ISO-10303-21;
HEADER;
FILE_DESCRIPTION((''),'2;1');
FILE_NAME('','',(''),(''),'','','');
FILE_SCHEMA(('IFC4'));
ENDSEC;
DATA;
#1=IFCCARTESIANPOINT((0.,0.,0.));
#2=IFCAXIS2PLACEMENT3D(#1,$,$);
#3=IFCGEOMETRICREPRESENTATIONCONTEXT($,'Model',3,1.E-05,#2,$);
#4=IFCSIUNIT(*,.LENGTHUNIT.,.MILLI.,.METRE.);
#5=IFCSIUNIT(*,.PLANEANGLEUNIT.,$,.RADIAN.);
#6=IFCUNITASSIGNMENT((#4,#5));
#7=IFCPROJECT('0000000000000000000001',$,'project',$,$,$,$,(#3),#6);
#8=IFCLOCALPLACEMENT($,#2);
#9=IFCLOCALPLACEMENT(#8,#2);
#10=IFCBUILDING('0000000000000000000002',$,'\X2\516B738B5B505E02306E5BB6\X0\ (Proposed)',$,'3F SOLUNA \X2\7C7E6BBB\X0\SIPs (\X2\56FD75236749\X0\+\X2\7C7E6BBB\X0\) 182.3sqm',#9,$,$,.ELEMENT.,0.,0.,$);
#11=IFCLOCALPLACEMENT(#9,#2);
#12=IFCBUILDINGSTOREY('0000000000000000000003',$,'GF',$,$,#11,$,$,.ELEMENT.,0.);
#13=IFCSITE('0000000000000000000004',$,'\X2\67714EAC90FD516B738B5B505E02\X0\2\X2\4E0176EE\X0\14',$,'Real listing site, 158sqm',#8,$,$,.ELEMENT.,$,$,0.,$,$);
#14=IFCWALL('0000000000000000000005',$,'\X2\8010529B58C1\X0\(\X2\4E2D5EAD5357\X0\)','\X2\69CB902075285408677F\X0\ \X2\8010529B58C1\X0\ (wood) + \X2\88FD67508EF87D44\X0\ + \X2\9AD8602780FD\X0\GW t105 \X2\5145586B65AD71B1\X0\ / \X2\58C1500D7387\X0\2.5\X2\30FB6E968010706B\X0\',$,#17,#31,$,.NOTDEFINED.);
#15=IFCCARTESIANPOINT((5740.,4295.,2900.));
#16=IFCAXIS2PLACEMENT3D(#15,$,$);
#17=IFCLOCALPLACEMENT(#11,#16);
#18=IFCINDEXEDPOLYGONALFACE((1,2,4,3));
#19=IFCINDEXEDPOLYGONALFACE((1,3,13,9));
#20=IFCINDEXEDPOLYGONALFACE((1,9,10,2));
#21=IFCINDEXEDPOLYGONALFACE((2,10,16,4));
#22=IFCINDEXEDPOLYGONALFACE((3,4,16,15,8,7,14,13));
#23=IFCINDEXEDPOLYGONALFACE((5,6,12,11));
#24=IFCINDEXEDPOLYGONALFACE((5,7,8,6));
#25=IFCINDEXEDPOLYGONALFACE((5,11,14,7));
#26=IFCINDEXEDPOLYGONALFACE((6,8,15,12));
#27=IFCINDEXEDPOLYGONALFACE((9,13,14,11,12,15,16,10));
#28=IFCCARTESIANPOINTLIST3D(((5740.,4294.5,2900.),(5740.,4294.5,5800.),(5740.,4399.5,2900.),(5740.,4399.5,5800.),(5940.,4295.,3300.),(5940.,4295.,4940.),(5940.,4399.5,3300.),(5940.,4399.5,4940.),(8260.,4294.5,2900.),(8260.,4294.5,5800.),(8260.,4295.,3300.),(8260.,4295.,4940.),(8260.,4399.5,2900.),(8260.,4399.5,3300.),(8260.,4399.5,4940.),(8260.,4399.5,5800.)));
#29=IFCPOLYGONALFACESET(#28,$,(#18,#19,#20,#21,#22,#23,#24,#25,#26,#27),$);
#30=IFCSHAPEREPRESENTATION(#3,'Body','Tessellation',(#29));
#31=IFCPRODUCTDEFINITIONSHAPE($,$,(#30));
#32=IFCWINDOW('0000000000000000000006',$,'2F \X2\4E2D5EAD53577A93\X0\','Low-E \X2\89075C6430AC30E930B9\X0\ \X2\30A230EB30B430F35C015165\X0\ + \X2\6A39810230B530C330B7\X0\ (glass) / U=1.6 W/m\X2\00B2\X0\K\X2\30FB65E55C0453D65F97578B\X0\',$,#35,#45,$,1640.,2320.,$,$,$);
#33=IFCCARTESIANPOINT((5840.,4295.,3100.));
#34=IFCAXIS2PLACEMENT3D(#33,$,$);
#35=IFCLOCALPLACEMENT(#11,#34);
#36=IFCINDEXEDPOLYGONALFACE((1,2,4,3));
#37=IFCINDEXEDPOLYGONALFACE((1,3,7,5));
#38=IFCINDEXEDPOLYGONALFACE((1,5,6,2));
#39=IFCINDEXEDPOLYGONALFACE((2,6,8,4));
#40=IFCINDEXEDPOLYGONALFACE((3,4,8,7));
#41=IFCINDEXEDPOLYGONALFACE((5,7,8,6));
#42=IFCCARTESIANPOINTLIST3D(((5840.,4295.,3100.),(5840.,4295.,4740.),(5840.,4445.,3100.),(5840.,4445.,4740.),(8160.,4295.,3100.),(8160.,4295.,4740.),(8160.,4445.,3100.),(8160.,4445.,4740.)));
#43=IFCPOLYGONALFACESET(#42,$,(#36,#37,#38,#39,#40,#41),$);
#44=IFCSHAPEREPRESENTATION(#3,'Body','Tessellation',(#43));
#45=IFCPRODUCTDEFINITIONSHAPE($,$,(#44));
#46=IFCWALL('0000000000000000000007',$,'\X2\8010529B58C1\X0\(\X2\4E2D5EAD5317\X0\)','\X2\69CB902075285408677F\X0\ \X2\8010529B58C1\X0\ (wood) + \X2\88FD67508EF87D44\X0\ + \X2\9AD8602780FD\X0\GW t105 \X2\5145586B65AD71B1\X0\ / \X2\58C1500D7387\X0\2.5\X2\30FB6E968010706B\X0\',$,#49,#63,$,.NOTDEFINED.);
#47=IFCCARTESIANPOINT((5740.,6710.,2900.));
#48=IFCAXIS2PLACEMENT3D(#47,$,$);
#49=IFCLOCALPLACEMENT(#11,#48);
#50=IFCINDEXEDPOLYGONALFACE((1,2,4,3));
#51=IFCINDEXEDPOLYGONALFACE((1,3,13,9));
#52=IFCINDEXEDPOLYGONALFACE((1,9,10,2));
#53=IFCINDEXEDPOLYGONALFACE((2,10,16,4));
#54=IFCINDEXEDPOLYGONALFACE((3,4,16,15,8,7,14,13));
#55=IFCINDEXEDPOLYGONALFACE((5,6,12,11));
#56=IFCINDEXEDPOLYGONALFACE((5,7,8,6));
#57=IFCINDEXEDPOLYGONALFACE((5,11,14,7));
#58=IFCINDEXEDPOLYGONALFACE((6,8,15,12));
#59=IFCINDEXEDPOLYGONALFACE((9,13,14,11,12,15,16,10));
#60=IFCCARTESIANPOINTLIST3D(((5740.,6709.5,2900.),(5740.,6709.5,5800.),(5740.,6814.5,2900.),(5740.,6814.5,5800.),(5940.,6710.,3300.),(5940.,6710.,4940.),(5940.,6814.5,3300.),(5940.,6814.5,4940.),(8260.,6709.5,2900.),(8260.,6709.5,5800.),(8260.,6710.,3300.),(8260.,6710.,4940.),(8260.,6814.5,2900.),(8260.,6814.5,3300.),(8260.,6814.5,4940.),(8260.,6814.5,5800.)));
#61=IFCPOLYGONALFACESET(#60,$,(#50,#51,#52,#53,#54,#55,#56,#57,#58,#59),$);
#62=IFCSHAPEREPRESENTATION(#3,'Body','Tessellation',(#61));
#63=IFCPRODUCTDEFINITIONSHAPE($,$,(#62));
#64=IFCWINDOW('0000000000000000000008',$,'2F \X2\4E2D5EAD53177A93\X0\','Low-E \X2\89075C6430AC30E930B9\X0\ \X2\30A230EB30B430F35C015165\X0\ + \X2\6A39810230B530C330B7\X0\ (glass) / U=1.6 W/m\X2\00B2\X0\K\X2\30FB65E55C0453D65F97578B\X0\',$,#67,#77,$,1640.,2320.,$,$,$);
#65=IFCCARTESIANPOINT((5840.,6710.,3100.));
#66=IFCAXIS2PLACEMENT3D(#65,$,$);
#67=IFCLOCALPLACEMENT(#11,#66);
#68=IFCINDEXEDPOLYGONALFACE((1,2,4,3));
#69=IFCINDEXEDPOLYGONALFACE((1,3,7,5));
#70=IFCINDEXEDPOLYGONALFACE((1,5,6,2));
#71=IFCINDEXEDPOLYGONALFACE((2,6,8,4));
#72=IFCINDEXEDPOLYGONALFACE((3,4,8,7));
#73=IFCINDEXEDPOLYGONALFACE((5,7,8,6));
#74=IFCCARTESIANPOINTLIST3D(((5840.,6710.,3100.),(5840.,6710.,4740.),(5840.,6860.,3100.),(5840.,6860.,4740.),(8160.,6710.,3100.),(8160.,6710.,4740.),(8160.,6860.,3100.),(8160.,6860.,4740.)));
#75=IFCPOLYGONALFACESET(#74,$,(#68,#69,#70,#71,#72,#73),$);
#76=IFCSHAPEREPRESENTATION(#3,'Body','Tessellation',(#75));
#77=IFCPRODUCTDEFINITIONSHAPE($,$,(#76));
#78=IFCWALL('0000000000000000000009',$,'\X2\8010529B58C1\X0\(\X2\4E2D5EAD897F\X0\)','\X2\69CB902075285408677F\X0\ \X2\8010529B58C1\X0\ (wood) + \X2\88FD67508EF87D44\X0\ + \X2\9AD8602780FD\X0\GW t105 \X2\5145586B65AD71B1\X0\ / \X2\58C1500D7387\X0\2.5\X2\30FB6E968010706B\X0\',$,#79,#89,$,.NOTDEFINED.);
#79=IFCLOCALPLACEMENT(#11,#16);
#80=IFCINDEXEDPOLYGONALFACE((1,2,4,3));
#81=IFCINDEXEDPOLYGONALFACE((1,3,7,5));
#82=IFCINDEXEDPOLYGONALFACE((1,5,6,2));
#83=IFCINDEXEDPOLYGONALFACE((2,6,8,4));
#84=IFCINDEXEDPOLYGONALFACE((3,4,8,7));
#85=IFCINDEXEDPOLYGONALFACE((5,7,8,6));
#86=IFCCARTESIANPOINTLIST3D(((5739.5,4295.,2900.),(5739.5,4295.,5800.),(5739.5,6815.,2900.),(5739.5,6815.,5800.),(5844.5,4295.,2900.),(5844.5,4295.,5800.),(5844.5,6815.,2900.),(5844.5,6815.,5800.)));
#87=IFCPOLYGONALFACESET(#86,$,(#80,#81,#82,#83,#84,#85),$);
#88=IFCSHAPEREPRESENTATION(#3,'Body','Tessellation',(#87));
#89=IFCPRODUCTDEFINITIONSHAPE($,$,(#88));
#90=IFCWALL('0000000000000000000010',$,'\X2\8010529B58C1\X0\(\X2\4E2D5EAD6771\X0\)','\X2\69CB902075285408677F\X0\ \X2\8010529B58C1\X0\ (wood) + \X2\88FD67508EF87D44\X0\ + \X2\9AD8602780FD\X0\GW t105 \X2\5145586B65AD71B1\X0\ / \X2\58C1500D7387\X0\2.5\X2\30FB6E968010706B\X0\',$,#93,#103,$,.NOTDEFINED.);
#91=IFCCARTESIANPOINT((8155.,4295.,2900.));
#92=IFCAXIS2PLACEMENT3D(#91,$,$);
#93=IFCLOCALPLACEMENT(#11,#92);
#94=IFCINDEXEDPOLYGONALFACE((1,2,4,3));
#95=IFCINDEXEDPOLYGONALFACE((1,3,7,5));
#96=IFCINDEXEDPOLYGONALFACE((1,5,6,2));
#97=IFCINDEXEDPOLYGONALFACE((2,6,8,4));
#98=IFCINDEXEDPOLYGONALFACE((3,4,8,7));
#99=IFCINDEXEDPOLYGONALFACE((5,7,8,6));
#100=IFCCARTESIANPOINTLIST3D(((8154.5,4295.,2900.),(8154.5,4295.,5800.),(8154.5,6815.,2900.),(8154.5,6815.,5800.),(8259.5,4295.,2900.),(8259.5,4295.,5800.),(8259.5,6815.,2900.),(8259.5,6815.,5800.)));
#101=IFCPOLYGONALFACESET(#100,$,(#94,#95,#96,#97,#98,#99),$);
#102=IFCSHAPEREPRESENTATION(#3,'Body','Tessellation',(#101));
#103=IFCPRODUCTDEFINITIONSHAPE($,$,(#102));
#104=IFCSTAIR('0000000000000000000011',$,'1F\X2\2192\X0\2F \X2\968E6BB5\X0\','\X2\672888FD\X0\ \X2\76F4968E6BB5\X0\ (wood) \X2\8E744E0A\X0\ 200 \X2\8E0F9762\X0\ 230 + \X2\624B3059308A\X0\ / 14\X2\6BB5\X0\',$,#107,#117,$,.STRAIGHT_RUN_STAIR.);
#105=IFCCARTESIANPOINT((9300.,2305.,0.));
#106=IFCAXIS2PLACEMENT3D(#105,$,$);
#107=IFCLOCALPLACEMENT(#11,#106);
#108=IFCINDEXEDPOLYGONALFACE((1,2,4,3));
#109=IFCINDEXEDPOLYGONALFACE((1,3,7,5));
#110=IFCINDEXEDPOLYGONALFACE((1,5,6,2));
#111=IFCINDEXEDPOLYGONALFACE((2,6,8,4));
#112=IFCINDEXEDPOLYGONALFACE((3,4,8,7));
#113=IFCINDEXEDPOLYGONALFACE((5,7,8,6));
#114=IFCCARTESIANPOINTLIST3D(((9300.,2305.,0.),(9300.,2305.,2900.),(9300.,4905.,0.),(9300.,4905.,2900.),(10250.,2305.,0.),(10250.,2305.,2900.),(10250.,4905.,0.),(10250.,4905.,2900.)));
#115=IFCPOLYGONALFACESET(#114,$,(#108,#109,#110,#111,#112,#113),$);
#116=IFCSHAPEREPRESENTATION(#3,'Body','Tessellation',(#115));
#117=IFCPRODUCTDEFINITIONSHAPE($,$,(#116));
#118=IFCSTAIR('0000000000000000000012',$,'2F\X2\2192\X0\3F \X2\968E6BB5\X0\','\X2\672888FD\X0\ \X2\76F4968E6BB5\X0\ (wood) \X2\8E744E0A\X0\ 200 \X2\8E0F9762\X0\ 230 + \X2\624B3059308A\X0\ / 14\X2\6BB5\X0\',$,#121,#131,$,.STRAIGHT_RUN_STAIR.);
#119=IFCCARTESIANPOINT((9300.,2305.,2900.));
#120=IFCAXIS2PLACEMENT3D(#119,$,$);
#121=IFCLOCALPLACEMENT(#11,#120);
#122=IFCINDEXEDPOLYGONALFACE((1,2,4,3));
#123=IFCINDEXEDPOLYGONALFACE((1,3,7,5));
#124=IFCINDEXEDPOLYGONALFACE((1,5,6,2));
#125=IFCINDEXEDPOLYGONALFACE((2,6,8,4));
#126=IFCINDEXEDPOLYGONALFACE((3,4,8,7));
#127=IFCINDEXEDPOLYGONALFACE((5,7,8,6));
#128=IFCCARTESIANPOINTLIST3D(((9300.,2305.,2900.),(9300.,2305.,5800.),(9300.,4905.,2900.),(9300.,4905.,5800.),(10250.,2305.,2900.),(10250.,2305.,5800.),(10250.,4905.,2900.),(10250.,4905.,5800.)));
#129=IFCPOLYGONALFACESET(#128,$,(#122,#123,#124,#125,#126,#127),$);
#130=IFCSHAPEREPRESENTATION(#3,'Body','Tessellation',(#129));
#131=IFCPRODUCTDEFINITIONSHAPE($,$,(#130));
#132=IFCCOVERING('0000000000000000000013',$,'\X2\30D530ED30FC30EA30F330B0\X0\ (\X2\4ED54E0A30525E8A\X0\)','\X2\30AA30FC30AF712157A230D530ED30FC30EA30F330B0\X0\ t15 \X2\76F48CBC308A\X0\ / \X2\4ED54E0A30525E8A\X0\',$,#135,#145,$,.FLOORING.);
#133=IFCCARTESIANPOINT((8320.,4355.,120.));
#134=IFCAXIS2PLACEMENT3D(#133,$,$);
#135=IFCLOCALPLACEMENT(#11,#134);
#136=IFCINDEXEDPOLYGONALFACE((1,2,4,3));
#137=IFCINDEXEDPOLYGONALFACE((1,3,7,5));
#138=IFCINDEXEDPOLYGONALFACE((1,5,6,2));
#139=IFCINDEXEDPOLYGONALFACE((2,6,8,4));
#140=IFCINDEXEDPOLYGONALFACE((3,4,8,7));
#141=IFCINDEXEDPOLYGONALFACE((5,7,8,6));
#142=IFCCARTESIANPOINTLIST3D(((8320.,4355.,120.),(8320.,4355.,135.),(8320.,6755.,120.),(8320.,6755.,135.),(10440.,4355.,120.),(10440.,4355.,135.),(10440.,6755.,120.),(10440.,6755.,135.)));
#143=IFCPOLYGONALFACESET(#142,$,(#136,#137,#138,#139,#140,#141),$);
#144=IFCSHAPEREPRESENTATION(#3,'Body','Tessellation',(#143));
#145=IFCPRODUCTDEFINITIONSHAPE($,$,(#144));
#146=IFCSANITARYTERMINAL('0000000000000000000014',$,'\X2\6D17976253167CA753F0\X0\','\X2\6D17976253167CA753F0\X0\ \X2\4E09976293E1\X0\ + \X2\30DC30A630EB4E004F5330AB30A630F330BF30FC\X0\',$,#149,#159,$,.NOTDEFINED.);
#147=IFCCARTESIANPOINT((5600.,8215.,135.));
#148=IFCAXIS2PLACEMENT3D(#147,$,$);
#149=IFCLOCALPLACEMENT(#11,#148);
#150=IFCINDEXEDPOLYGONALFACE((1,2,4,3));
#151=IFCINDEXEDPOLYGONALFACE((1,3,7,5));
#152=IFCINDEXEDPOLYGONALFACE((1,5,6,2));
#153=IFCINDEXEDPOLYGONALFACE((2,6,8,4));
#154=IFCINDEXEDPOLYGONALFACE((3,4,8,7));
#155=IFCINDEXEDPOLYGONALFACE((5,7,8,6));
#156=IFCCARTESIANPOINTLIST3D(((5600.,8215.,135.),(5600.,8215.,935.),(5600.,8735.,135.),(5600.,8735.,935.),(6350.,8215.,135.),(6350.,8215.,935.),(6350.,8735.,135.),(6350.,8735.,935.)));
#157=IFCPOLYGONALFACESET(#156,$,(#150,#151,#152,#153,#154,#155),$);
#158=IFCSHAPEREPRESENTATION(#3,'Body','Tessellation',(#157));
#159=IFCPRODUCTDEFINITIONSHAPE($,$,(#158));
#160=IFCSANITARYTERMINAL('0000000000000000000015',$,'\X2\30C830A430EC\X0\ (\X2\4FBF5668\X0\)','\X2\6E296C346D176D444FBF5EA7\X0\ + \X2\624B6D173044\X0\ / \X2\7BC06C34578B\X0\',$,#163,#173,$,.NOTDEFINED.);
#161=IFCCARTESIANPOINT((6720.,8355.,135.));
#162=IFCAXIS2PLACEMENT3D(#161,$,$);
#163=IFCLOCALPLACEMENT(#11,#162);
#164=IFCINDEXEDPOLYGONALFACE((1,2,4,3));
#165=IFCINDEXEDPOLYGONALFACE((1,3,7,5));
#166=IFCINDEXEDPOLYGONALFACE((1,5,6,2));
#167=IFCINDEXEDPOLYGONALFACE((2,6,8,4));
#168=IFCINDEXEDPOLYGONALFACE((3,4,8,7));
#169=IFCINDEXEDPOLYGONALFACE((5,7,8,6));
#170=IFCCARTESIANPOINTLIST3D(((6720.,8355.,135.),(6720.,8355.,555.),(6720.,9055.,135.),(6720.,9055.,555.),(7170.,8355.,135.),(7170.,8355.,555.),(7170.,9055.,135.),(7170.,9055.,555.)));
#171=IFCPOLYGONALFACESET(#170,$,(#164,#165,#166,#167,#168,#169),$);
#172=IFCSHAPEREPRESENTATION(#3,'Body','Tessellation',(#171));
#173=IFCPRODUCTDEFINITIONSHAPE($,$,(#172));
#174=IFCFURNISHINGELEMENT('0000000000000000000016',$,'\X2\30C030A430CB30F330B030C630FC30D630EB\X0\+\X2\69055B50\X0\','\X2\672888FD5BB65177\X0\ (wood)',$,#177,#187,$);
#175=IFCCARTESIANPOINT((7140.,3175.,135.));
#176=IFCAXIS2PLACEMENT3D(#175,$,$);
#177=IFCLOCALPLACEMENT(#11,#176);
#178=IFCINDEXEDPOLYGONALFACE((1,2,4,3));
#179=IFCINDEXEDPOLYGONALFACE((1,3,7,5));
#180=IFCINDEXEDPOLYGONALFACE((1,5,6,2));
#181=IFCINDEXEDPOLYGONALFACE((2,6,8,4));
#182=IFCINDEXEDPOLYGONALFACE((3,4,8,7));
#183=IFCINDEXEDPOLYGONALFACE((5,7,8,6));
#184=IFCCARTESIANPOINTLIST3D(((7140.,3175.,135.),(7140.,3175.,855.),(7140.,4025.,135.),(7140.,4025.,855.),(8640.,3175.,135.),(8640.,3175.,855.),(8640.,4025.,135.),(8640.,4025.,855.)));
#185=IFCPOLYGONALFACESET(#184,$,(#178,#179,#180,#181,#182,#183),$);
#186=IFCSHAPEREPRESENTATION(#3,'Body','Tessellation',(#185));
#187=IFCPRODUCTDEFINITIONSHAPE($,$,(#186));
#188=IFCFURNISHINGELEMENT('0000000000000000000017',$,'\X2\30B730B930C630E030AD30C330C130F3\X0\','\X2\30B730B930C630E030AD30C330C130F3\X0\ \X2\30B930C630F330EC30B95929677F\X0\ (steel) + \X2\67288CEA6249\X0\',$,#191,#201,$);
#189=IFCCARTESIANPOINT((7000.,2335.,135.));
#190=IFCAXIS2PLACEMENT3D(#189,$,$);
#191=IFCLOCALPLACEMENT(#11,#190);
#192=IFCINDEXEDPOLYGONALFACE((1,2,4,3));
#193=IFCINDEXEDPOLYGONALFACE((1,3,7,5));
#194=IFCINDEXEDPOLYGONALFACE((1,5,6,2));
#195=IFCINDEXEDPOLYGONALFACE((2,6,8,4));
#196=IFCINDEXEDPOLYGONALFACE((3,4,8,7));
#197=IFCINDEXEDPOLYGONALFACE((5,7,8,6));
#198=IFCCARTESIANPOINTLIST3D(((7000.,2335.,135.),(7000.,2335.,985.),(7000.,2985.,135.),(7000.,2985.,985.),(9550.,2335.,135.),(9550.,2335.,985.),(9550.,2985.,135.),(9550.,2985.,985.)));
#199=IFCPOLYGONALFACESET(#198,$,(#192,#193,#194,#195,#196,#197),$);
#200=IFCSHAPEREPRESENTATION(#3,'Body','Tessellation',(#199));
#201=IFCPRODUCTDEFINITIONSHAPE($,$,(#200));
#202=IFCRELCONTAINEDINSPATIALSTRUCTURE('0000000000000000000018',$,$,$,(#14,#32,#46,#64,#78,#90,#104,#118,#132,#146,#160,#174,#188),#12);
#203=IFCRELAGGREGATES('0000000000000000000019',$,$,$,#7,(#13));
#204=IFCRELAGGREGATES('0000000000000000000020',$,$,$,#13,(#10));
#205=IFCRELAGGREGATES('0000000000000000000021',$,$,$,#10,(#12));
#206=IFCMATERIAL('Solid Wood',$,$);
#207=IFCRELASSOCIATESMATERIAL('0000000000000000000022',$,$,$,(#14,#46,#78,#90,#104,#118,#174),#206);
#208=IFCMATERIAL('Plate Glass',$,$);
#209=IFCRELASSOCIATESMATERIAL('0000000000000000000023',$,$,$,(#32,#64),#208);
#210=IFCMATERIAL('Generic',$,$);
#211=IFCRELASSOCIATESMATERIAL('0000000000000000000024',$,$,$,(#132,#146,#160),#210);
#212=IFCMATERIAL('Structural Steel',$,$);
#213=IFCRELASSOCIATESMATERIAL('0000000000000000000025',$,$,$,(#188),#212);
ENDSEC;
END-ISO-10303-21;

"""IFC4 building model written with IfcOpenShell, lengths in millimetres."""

from ifc_helpers import new_model, si_unit, frame, frame_2d, origin, place, context, project, spatial, rectangle, extrude, material, element, fill, save


model = new_model("IFC4")

# Units and contexts
model_context = context("Model", 3, precision=1e-05, world=origin())
ifc_project = project(units=[si_unit("LENGTHUNIT", "METRE", prefix="MILLI"), si_unit("PLANEANGLEUNIT", "RADIAN")], contexts=[model_context])

# Site, building, storey
site_placement = place(None, origin())
site = spatial("IfcSite", under=ifc_project, at=site_placement, Name="東京都八王子市2丁目14", ObjectType="Real listing site, 158sqm", CompositionType="ELEMENT", RefElevation=0.0)
building_placement = place(site_placement, origin())
building = spatial("IfcBuilding", under=site, at=building_placement, Name="八王子市の家 (Proposed)", ObjectType="3F SOLUNA 籾殻SIPs (国産杉+籾殻) 182.3sqm", CompositionType="ELEMENT", ElevationOfRefHeight=0.0, ElevationOfTerrain=0.0)
storey_placement = place(building_placement, origin())
storey = spatial("IfcBuildingStorey", under=building, at=storey_placement, Name="GF", CompositionType="ELEMENT", Elevation=0.0)

# Shared definitions
ifc_material_1 = material(Name="Solid Wood")

# Shared definitions
ifc_material_2 = material(Name="Plate Glass")

# Walls, openings, windows
wall_1_placement = place(storey_placement, frame((5740.0, 4295.0, 2900.0)))
wall_1 = element("IfcWall", 1, at=wall_1_placement, inside=storey, material=ifc_material_1, Name="耐力壁(中庭南)", Description="構造用合板 耐力壁 (wood) + 製材軸組 + 高性能GW t105 充填断熱 / 壁倍率2.5・準耐火", PredefinedType="NOTDEFINED", context=model_context, shape_type="SweptSolid", body=[
    extrude(rectangle(XDim=2520.0, YDim=105.0, at=frame_2d((1260.0, 52.0))), frame((5740.0, 4295.0, 2900.0)), (0.0, 0.0, 1.0), 2900.0),
])
opening_1_placement = place(storey_placement, frame((5840.0, 4295.0, 3100.0)))
opening_1 = element("IfcOpeningElement", 2, at=opening_1_placement, cuts=wall_1, PredefinedType="NOTDEFINED", context=model_context, shape_type="SweptSolid", body=[
    extrude(rectangle(XDim=2320.0, YDim=150.0, at=frame_2d((1160.0, 75.0))), frame((5840.0, 4295.0, 3100.0)), (0.0, 0.0, 1.0), 1640.0),
])
window_1_placement = place(storey_placement, frame((5840.0, 4295.0, 3100.0)))
window_1 = element("IfcWindow", 3, at=window_1_placement, inside=storey, material=ifc_material_2, Name="2F 中庭南窓", Description="Low-E 複層ガラス アルゴン封入 + 樹脂サッシ (glass) / U=1.6 W/m²K・日射取得型", OverallHeight=1640.0, OverallWidth=2320.0, context=model_context, shape_type="SweptSolid", body=[
    extrude(rectangle(XDim=2320.0, YDim=150.0, at=frame_2d((1160.0, 75.0))), frame((5840.0, 4295.0, 3100.0)), (0.0, 0.0, 1.0), 1640.0),
])
fill(opening_1, window_1)
wall_2_placement = place(storey_placement, frame((5740.0, 6710.0, 2900.0)))
wall_2 = element("IfcWall", 4, at=wall_2_placement, inside=storey, material=ifc_material_1, Name="耐力壁(中庭北)", Description="構造用合板 耐力壁 (wood) + 製材軸組 + 高性能GW t105 充填断熱 / 壁倍率2.5・準耐火", PredefinedType="NOTDEFINED", context=model_context, shape_type="SweptSolid", body=[
    extrude(rectangle(XDim=2520.0, YDim=105.0, at=frame_2d((1260.0, 52.0))), frame((5740.0, 6710.0, 2900.0)), (0.0, 0.0, 1.0), 2900.0),
])
opening_2_placement = place(storey_placement, frame((5840.0, 6710.0, 3100.0)))
opening_2 = element("IfcOpeningElement", 5, at=opening_2_placement, cuts=wall_2, PredefinedType="NOTDEFINED", context=model_context, shape_type="SweptSolid", body=[
    extrude(rectangle(XDim=2320.0, YDim=150.0, at=frame_2d((1160.0, 75.0))), frame((5840.0, 6710.0, 3100.0)), (0.0, 0.0, 1.0), 1640.0),
])
window_2_placement = place(storey_placement, frame((5840.0, 6710.0, 3100.0)))
window_2 = element("IfcWindow", 6, at=window_2_placement, inside=storey, material=ifc_material_2, Name="2F 中庭北窓", Description="Low-E 複層ガラス アルゴン封入 + 樹脂サッシ (glass) / U=1.6 W/m²K・日射取得型", OverallHeight=1640.0, OverallWidth=2320.0, context=model_context, shape_type="SweptSolid", body=[
    extrude(rectangle(XDim=2320.0, YDim=150.0, at=frame_2d((1160.0, 75.0))), frame((5840.0, 6710.0, 3100.0)), (0.0, 0.0, 1.0), 1640.0),
])
fill(opening_2, window_2)

# Walls
wall_3_placement = place(storey_placement, frame((5740.0, 4295.0, 2900.0)))
element("IfcWall", 7, at=wall_3_placement, inside=storey, material=ifc_material_1, Name="耐力壁(中庭西)", Description="構造用合板 耐力壁 (wood) + 製材軸組 + 高性能GW t105 充填断熱 / 壁倍率2.5・準耐火", PredefinedType="NOTDEFINED", context=model_context, shape_type="SweptSolid", body=[
    extrude(rectangle(XDim=105.0, YDim=2520.0, at=frame_2d((52.0, 1260.0))), frame((5740.0, 4295.0, 2900.0)), (0.0, 0.0, 1.0), 2900.0),
])
wall_4_placement = place(storey_placement, frame((8155.0, 4295.0, 2900.0)))
element("IfcWall", 8, at=wall_4_placement, inside=storey, material=ifc_material_1, Name="耐力壁(中庭東)", Description="構造用合板 耐力壁 (wood) + 製材軸組 + 高性能GW t105 充填断熱 / 壁倍率2.5・準耐火", PredefinedType="NOTDEFINED", context=model_context, shape_type="SweptSolid", body=[
    extrude(rectangle(XDim=105.0, YDim=2520.0, at=frame_2d((52.0, 1260.0))), frame((8155.0, 4295.0, 2900.0)), (0.0, 0.0, 1.0), 2900.0),
])

# Stairs
stair_1_placement = place(storey_placement, frame((9300.0, 2305.0, 0.0)))
element("IfcStair", 9, at=stair_1_placement, inside=storey, material=ifc_material_1, Name="1F→2F 階段", Description="木製 直階段 (wood) 蹴上 200 踏面 230 + 手すり / 14段", PredefinedType="STRAIGHT_RUN_STAIR", context=model_context, shape_type="SweptSolid", body=[
    extrude(rectangle(XDim=950.0, YDim=2600.0, at=frame_2d((475.0, 1300.0))), frame((9300.0, 2305.0, 0.0)), (0.0, 0.0, 1.0), 2900.0),
])
stair_2_placement = place(storey_placement, frame((9300.0, 2305.0, 2900.0)))
element("IfcStair", 10, at=stair_2_placement, inside=storey, material=ifc_material_1, Name="2F→3F 階段", Description="木製 直階段 (wood) 蹴上 200 踏面 230 + 手すり / 14段", PredefinedType="STRAIGHT_RUN_STAIR", context=model_context, shape_type="SweptSolid", body=[
    extrude(rectangle(XDim=950.0, YDim=2600.0, at=frame_2d((475.0, 1300.0))), frame((9300.0, 2305.0, 2900.0)), (0.0, 0.0, 1.0), 2900.0),
])

# Covering
ifc_material_3 = material(Name="Generic")
covering_placement = place(storey_placement, frame((8320.0, 4355.0, 120.0)))
element("IfcCovering", 11, at=covering_placement, inside=storey, material=ifc_material_3, Name="フローリング (仕上げ床)", Description="オーク無垢フローリング t15 直貼り / 仕上げ床", PredefinedType="FLOORING", context=model_context, shape_type="SweptSolid", body=[
    extrude(rectangle(XDim=2120.0, YDim=2400.0, at=frame_2d((1060.0, 1200.0))), frame((8320.0, 4355.0, 120.0)), (0.0, 0.0, 1.0), 15.0),
])

# Sanitary terminals
sanitary_terminal_1_placement = place(storey_placement, frame((5600.0, 8215.0, 135.0)))
element("IfcSanitaryTerminal", 12, at=sanitary_terminal_1_placement, inside=storey, material=ifc_material_3, Name="洗面化粧台", Description="洗面化粧台 三面鏡 + ボウル一体カウンター", PredefinedType="NOTDEFINED", context=model_context, shape_type="SweptSolid", body=[
    extrude(rectangle(XDim=750.0, YDim=520.0, at=frame_2d((375.0, 260.0))), frame((5600.0, 8215.0, 135.0)), (0.0, 0.0, 1.0), 800.0),
])
sanitary_terminal_2_placement = place(storey_placement, frame((6720.0, 8355.0, 135.0)))
element("IfcSanitaryTerminal", 13, at=sanitary_terminal_2_placement, inside=storey, material=ifc_material_3, Name="トイレ (便器)", Description="温水洗浄便座 + 手洗い / 節水型", PredefinedType="NOTDEFINED", context=model_context, shape_type="SweptSolid", body=[
    extrude(rectangle(XDim=450.0, YDim=700.0, at=frame_2d((225.0, 350.0))), frame((6720.0, 8355.0, 135.0)), (0.0, 0.0, 1.0), 420.0),
])

# Furnishing elements
furnishing_1_placement = place(storey_placement, frame((7140.0, 3175.0, 135.0)))
element("IfcFurnishingElement", 14, at=furnishing_1_placement, inside=storey, material=ifc_material_1, Name="ダイニングテーブル+椅子", Description="木製家具 (wood)", context=model_context, shape_type="SweptSolid", body=[
    extrude(rectangle(XDim=1500.0, YDim=850.0, at=frame_2d((750.0, 425.0))), frame((7140.0, 3175.0, 135.0)), (0.0, 0.0, 1.0), 720.0),
])
ifc_material_4 = material(Name="Structural Steel")
furnishing_2_placement = place(storey_placement, frame((7000.0, 2335.0, 135.0)))
element("IfcFurnishingElement", 15, at=furnishing_2_placement, inside=storey, material=ifc_material_4, Name="システムキッチン", Description="システムキッチン ステンレス天板 (steel) + 木質扉", context=model_context, shape_type="SweptSolid", body=[
    extrude(rectangle(XDim=2550.0, YDim=650.0, at=frame_2d((1275.0, 325.0))), frame((7000.0, 2335.0, 135.0)), (0.0, 0.0, 1.0), 850.0),
])

save(model, "model.ifc")
